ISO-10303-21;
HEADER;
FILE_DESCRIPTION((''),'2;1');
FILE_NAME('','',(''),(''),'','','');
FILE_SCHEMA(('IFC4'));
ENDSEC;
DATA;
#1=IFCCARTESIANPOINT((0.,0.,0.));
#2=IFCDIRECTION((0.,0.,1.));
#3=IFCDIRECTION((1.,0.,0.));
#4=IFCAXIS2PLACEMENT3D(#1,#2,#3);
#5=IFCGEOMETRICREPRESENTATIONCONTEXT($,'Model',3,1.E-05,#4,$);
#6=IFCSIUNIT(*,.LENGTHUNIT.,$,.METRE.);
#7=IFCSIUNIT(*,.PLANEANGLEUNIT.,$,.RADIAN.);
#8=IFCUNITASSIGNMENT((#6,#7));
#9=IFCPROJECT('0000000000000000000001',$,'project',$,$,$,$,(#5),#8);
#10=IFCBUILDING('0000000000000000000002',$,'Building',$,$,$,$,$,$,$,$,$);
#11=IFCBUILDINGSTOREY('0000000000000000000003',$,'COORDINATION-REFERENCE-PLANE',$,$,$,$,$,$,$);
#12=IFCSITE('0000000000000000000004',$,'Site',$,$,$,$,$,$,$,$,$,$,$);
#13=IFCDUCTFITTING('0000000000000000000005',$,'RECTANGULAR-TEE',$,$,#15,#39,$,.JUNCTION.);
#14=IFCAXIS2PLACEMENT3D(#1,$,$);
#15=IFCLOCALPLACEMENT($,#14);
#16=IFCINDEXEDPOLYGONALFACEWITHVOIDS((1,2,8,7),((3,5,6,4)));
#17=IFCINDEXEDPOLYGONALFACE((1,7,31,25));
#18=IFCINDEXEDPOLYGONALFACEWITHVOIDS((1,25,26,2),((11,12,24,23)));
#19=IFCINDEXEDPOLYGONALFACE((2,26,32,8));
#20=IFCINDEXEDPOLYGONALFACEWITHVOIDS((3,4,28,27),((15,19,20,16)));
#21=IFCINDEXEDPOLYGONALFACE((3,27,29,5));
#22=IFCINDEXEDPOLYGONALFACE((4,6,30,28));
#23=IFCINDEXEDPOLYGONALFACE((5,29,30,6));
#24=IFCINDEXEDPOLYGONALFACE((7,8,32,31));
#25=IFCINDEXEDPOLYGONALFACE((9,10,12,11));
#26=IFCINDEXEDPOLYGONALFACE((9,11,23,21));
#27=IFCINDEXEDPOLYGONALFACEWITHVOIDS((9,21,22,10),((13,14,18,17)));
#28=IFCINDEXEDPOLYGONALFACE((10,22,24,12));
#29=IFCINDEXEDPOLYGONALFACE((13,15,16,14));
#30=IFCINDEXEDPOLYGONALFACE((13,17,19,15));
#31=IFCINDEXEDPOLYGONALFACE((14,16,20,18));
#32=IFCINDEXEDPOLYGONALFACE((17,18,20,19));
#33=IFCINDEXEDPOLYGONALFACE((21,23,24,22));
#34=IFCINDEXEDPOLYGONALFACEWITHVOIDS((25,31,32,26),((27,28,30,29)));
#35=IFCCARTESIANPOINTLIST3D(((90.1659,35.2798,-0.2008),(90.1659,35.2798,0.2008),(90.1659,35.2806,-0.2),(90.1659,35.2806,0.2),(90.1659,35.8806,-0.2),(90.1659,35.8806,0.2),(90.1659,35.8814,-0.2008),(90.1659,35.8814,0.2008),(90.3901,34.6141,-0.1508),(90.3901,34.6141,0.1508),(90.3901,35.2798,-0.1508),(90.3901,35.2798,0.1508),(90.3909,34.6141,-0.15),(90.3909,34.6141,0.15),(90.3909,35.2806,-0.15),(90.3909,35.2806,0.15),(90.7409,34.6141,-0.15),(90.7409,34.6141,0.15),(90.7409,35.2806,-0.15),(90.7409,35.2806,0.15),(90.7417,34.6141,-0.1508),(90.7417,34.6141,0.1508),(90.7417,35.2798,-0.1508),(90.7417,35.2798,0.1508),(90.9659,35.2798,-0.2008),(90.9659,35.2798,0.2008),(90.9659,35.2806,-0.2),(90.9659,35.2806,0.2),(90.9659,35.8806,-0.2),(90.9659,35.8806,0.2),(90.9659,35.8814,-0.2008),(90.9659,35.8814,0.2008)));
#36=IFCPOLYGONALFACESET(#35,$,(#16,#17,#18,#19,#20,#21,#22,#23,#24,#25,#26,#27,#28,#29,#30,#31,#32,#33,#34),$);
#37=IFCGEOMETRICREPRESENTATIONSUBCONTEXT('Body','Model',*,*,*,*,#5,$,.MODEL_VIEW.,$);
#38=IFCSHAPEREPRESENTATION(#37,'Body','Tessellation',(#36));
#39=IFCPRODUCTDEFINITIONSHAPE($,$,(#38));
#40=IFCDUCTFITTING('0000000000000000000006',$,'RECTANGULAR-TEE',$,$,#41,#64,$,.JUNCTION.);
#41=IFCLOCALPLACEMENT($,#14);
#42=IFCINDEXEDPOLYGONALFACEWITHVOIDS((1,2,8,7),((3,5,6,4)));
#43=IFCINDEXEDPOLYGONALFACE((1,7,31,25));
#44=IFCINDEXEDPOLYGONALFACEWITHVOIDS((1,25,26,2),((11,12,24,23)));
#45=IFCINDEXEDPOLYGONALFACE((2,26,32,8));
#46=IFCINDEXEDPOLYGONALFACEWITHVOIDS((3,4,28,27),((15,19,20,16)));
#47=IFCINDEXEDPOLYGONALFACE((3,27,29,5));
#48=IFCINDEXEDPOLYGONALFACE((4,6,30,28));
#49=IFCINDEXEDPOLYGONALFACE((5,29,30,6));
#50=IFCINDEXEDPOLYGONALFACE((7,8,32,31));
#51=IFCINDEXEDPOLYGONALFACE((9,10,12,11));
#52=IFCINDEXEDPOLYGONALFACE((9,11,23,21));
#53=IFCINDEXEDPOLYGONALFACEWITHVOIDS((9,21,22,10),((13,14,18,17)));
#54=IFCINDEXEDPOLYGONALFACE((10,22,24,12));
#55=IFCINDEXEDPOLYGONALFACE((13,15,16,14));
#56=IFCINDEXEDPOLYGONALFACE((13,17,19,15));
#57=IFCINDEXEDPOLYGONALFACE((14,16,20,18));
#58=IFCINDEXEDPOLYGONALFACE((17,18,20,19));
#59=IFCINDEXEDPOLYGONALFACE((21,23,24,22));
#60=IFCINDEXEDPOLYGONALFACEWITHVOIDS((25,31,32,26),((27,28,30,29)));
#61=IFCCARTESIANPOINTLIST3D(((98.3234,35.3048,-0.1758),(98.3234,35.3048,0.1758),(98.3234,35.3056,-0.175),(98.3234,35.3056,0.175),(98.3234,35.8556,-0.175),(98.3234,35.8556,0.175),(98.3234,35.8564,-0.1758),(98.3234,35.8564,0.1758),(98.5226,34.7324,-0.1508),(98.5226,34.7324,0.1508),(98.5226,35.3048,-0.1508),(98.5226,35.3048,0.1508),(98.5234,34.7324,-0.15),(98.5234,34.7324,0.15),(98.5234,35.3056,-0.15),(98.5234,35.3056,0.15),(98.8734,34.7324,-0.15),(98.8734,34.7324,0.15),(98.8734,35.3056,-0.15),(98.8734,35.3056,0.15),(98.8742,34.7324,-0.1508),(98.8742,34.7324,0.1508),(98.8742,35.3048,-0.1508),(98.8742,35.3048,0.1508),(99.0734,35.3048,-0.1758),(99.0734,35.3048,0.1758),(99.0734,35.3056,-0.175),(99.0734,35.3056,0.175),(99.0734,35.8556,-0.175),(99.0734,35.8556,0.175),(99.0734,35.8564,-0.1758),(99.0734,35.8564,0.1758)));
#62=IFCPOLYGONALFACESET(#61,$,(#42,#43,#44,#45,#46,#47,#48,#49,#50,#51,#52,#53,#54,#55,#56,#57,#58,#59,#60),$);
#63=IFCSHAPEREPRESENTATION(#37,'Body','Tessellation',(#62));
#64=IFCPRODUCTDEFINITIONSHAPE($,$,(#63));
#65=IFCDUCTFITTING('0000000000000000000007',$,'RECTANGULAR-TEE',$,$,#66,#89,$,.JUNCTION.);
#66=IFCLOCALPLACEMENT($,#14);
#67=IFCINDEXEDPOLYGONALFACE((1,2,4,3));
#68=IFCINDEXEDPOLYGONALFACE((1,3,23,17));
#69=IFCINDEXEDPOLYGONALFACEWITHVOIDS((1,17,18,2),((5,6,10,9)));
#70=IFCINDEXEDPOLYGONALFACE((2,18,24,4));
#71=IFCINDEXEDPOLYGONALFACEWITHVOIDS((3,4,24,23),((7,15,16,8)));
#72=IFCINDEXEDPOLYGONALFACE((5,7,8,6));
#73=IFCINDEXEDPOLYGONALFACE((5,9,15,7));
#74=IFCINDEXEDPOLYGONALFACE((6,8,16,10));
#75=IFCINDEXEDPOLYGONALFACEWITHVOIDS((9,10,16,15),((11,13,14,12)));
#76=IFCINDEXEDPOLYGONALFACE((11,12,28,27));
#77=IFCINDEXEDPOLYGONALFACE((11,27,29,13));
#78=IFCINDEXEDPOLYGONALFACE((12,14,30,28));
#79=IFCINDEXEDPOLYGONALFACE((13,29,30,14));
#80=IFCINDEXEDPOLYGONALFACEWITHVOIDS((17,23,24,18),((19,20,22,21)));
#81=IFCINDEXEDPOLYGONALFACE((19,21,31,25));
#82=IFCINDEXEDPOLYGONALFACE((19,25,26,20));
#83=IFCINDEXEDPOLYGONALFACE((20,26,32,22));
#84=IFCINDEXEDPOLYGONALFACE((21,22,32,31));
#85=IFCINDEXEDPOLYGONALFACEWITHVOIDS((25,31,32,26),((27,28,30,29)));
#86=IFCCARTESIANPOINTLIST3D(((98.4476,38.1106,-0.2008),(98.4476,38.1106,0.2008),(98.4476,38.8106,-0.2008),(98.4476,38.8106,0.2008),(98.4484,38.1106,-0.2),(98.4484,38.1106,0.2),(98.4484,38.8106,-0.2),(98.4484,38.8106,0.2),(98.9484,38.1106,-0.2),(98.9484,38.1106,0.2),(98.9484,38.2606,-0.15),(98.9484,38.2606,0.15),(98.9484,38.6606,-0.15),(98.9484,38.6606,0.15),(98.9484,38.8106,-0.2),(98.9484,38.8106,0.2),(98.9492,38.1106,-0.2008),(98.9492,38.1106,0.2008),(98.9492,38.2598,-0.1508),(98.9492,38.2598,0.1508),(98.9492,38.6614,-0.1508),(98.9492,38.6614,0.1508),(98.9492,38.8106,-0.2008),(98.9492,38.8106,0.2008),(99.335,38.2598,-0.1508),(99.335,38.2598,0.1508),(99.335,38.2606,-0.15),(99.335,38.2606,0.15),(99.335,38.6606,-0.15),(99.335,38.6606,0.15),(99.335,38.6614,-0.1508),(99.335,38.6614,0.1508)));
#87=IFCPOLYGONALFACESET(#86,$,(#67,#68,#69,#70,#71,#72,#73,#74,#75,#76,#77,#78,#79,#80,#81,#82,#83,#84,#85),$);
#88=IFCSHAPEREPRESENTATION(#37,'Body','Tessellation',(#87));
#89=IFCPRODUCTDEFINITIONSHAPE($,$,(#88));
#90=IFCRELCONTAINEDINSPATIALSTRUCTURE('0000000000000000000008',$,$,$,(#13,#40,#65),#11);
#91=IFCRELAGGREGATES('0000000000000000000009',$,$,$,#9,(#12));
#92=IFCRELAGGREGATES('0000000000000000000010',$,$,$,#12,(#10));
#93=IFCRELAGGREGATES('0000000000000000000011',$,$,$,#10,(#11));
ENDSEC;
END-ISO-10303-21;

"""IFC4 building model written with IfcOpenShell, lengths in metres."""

from ifc_helpers import new_model, si_unit, frame, origin_with_axes, place, context, subcontext, project, spatial, rectangle, extrude, boolean, element, save


model = new_model("IFC4")

# Units and contexts
model_context = context("Model", 3, precision=1e-05, world=origin_with_axes())
body_context = subcontext(model_context, "Body", "Model", "MODEL_VIEW")
ifc_project = project(units=[si_unit("LENGTHUNIT", "METRE"), si_unit("PLANEANGLEUNIT", "RADIAN")], contexts=[model_context])

# Site, building, storey
site = spatial("IfcSite", under=ifc_project, Name="Site")
building = spatial("IfcBuilding", under=site, Name="Building")
storey = spatial("IfcBuildingStorey", under=building, Name="COORDINATION-REFERENCE-PLANE")

# Duct fittings
duct_fitting_1_placement = place(None, frame((90.5659, 35.5806, 0.0), z_axis=(1.0, 0.0, 0.0), x_axis=(0.0, -1.0, 0.0)))
solid_1 = boolean("UNION", extrude(rectangle(XDim=0.6, YDim=0.4), frame((0.0, 0.0, -0.4), z_axis=(0.0, 0.0, 1.0), x_axis=(1.0, 0.0, 0.0)), (0.0, 0.0, 1.0), 0.8), extrude(rectangle(XDim=0.35, YDim=0.3), frame((0.0, 0.0, 0.0), z_axis=(1.0, 0.0, 0.0), x_axis=(0.0, 0.0, -1.0)), (0.0, 0.0, 1.0), 0.9665))
element("IfcDuctFitting", 1, at=duct_fitting_1_placement, inside=storey, Name="RECTANGULAR-TEE", PredefinedType="JUNCTION", context=body_context, shape_type="CSG", body=[
    boolean("DIFFERENCE", boolean("UNION", extrude(rectangle(XDim=0.6016, YDim=0.4016), frame((0.0, 0.0, -0.4), z_axis=(0.0, 0.0, 1.0), x_axis=(1.0, 0.0, 0.0)), (0.0, 0.0, 1.0), 0.8), extrude(rectangle(XDim=0.3516, YDim=0.3016), frame((0.0, 0.0, 0.0), z_axis=(1.0, 0.0, 0.0), x_axis=(0.0, 0.0, -1.0)), (0.0, 0.0, 1.0), 0.9665)), solid_1),
])
duct_fitting_2_placement = place(None, frame((98.6984, 35.5806, 0.0), z_axis=(1.0, 0.0, 0.0), x_axis=(0.0, -1.0, 0.0)))
solid_2 = boolean("UNION", extrude(rectangle(XDim=0.55, YDim=0.35), frame((0.0, 0.0, -0.375), z_axis=(0.0, 0.0, 1.0), x_axis=(1.0, 0.0, 0.0)), (0.0, 0.0, 1.0), 0.75), extrude(rectangle(XDim=0.35, YDim=0.3), frame((0.0, 0.0, 0.0), z_axis=(1.0, 0.0, 0.0), x_axis=(0.0, 0.0, -1.0)), (0.0, 0.0, 1.0), 0.8482))
element("IfcDuctFitting", 2, at=duct_fitting_2_placement, inside=storey, Name="RECTANGULAR-TEE", PredefinedType="JUNCTION", context=body_context, shape_type="CSG", body=[
    boolean("DIFFERENCE", boolean("UNION", extrude(rectangle(XDim=0.5516, YDim=0.3516), frame((0.0, 0.0, -0.375), z_axis=(0.0, 0.0, 1.0), x_axis=(1.0, 0.0, 0.0)), (0.0, 0.0, 1.0), 0.75), extrude(rectangle(XDim=0.3516, YDim=0.3016), frame((0.0, 0.0, 0.0), z_axis=(1.0, 0.0, 0.0), x_axis=(0.0, 0.0, -1.0)), (0.0, 0.0, 1.0), 0.8482)), solid_2),
])
duct_fitting_3_placement = place(None, frame((98.6984, 38.4606, 0.0), z_axis=(0.0, 1.0, 0.0), x_axis=(1.0, 0.0, 0.0)))
solid_3 = boolean("UNION", extrude(rectangle(XDim=0.5, YDim=0.4), frame((0.0, 0.0, -0.35), z_axis=(0.0, 0.0, 1.0), x_axis=(1.0, 0.0, 0.0)), (0.0, 0.0, 1.0), 0.7), extrude(rectangle(XDim=0.4, YDim=0.3), frame((0.0, 0.0, 0.0), z_axis=(1.0, 0.0, 0.0), x_axis=(0.0, 0.0, -1.0)), (0.0, 0.0, 1.0), 0.6366))
element("IfcDuctFitting", 3, at=duct_fitting_3_placement, inside=storey, Name="RECTANGULAR-TEE", PredefinedType="JUNCTION", context=body_context, shape_type="CSG", body=[
    boolean("DIFFERENCE", boolean("UNION", extrude(rectangle(XDim=0.5016, YDim=0.4016), frame((0.0, 0.0, -0.35), z_axis=(0.0, 0.0, 1.0), x_axis=(1.0, 0.0, 0.0)), (0.0, 0.0, 1.0), 0.7), extrude(rectangle(XDim=0.4016, YDim=0.3016), frame((0.0, 0.0, 0.0), z_axis=(1.0, 0.0, 0.0), x_axis=(0.0, 0.0, -1.0)), (0.0, 0.0, 1.0), 0.6366)), solid_3),
])

save(model, "model.ifc")
